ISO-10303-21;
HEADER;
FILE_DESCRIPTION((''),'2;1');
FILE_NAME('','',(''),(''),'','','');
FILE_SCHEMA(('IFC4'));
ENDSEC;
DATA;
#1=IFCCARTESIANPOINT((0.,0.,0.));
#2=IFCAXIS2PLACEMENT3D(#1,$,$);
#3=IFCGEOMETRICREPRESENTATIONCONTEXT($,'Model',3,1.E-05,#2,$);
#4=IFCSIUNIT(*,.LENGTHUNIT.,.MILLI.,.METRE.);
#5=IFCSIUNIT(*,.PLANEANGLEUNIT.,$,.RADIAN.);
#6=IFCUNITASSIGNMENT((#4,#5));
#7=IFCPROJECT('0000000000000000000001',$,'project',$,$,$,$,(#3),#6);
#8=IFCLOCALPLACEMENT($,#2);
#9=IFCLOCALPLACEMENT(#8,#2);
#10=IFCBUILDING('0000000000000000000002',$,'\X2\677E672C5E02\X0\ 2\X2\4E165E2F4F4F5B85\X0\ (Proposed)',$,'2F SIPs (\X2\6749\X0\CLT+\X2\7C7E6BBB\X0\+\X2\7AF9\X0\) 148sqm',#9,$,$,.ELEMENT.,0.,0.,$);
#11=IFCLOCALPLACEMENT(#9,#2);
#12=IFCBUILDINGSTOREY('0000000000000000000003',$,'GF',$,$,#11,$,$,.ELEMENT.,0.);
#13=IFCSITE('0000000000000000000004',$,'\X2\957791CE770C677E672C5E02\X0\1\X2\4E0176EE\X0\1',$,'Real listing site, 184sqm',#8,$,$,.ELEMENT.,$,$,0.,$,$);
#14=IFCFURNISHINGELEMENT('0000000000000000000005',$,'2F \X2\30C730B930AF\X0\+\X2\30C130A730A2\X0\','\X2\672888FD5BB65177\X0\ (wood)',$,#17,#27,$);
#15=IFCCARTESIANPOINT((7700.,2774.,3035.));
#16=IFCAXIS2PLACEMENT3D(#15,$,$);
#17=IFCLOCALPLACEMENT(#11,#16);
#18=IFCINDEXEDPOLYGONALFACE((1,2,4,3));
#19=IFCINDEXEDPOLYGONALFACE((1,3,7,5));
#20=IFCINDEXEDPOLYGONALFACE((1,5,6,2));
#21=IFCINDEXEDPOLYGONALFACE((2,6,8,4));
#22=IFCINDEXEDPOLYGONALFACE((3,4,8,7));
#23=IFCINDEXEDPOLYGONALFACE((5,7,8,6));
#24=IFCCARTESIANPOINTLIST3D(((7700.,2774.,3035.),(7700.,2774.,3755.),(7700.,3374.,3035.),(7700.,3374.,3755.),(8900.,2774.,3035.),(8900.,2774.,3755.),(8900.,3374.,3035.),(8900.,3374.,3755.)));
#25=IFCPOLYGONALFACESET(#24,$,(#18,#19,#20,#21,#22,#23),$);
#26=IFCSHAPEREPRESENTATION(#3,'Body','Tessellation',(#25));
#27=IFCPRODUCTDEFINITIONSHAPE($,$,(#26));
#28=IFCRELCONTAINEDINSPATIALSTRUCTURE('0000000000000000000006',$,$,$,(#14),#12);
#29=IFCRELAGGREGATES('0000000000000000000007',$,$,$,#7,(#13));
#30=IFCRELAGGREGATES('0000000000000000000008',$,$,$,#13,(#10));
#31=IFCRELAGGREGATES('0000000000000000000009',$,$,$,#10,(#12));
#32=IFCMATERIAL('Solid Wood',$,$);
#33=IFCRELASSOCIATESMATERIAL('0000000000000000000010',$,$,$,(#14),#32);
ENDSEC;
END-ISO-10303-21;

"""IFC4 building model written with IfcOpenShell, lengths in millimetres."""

from ifc_helpers import new_model, si_unit, frame, frame_2d, origin, place, context, project, spatial, rectangle, extrude, material, element, save


model = new_model("IFC4")

# Units and contexts
model_context = context("Model", 3, precision=1e-05, world=origin())
ifc_project = project(units=[si_unit("LENGTHUNIT", "METRE", prefix="MILLI"), si_unit("PLANEANGLEUNIT", "RADIAN")], contexts=[model_context])

# Site, building, storey
site_placement = place(None, origin())
site = spatial("IfcSite", under=ifc_project, at=site_placement, Name="長野県松本市1丁目1", ObjectType="Real listing site, 184sqm", CompositionType="ELEMENT", RefElevation=0.0)
building_placement = place(site_placement, origin())
building = spatial("IfcBuilding", under=site, at=building_placement, Name="松本市 2世帯住宅 (Proposed)", ObjectType="2F SIPs (杉CLT+籾殻+竹) 148sqm", CompositionType="ELEMENT", ElevationOfRefHeight=0.0, ElevationOfTerrain=0.0)
storey_placement = place(building_placement, origin())
storey = spatial("IfcBuildingStorey", under=building, at=storey_placement, Name="GF", CompositionType="ELEMENT", Elevation=0.0)

# Shared definitions
ifc_material_1 = material(Name="Solid Wood")

# Furnishing element
furnishing_1_placement = place(storey_placement, frame((7700.0, 2774.0, 3035.0)))
element("IfcFurnishingElement", 1, at=furnishing_1_placement, inside=storey, material=ifc_material_1, Name="2F デスク+チェア", Description="木製家具 (wood)", context=model_context, shape_type="SweptSolid", body=[
    extrude(rectangle(XDim=1200.0, YDim=600.0, at=frame_2d((600.0, 300.0))), frame((7700.0, 2774.0, 3035.0)), (0.0, 0.0, 1.0), 720.0),
])

save(model, "model.ifc")
